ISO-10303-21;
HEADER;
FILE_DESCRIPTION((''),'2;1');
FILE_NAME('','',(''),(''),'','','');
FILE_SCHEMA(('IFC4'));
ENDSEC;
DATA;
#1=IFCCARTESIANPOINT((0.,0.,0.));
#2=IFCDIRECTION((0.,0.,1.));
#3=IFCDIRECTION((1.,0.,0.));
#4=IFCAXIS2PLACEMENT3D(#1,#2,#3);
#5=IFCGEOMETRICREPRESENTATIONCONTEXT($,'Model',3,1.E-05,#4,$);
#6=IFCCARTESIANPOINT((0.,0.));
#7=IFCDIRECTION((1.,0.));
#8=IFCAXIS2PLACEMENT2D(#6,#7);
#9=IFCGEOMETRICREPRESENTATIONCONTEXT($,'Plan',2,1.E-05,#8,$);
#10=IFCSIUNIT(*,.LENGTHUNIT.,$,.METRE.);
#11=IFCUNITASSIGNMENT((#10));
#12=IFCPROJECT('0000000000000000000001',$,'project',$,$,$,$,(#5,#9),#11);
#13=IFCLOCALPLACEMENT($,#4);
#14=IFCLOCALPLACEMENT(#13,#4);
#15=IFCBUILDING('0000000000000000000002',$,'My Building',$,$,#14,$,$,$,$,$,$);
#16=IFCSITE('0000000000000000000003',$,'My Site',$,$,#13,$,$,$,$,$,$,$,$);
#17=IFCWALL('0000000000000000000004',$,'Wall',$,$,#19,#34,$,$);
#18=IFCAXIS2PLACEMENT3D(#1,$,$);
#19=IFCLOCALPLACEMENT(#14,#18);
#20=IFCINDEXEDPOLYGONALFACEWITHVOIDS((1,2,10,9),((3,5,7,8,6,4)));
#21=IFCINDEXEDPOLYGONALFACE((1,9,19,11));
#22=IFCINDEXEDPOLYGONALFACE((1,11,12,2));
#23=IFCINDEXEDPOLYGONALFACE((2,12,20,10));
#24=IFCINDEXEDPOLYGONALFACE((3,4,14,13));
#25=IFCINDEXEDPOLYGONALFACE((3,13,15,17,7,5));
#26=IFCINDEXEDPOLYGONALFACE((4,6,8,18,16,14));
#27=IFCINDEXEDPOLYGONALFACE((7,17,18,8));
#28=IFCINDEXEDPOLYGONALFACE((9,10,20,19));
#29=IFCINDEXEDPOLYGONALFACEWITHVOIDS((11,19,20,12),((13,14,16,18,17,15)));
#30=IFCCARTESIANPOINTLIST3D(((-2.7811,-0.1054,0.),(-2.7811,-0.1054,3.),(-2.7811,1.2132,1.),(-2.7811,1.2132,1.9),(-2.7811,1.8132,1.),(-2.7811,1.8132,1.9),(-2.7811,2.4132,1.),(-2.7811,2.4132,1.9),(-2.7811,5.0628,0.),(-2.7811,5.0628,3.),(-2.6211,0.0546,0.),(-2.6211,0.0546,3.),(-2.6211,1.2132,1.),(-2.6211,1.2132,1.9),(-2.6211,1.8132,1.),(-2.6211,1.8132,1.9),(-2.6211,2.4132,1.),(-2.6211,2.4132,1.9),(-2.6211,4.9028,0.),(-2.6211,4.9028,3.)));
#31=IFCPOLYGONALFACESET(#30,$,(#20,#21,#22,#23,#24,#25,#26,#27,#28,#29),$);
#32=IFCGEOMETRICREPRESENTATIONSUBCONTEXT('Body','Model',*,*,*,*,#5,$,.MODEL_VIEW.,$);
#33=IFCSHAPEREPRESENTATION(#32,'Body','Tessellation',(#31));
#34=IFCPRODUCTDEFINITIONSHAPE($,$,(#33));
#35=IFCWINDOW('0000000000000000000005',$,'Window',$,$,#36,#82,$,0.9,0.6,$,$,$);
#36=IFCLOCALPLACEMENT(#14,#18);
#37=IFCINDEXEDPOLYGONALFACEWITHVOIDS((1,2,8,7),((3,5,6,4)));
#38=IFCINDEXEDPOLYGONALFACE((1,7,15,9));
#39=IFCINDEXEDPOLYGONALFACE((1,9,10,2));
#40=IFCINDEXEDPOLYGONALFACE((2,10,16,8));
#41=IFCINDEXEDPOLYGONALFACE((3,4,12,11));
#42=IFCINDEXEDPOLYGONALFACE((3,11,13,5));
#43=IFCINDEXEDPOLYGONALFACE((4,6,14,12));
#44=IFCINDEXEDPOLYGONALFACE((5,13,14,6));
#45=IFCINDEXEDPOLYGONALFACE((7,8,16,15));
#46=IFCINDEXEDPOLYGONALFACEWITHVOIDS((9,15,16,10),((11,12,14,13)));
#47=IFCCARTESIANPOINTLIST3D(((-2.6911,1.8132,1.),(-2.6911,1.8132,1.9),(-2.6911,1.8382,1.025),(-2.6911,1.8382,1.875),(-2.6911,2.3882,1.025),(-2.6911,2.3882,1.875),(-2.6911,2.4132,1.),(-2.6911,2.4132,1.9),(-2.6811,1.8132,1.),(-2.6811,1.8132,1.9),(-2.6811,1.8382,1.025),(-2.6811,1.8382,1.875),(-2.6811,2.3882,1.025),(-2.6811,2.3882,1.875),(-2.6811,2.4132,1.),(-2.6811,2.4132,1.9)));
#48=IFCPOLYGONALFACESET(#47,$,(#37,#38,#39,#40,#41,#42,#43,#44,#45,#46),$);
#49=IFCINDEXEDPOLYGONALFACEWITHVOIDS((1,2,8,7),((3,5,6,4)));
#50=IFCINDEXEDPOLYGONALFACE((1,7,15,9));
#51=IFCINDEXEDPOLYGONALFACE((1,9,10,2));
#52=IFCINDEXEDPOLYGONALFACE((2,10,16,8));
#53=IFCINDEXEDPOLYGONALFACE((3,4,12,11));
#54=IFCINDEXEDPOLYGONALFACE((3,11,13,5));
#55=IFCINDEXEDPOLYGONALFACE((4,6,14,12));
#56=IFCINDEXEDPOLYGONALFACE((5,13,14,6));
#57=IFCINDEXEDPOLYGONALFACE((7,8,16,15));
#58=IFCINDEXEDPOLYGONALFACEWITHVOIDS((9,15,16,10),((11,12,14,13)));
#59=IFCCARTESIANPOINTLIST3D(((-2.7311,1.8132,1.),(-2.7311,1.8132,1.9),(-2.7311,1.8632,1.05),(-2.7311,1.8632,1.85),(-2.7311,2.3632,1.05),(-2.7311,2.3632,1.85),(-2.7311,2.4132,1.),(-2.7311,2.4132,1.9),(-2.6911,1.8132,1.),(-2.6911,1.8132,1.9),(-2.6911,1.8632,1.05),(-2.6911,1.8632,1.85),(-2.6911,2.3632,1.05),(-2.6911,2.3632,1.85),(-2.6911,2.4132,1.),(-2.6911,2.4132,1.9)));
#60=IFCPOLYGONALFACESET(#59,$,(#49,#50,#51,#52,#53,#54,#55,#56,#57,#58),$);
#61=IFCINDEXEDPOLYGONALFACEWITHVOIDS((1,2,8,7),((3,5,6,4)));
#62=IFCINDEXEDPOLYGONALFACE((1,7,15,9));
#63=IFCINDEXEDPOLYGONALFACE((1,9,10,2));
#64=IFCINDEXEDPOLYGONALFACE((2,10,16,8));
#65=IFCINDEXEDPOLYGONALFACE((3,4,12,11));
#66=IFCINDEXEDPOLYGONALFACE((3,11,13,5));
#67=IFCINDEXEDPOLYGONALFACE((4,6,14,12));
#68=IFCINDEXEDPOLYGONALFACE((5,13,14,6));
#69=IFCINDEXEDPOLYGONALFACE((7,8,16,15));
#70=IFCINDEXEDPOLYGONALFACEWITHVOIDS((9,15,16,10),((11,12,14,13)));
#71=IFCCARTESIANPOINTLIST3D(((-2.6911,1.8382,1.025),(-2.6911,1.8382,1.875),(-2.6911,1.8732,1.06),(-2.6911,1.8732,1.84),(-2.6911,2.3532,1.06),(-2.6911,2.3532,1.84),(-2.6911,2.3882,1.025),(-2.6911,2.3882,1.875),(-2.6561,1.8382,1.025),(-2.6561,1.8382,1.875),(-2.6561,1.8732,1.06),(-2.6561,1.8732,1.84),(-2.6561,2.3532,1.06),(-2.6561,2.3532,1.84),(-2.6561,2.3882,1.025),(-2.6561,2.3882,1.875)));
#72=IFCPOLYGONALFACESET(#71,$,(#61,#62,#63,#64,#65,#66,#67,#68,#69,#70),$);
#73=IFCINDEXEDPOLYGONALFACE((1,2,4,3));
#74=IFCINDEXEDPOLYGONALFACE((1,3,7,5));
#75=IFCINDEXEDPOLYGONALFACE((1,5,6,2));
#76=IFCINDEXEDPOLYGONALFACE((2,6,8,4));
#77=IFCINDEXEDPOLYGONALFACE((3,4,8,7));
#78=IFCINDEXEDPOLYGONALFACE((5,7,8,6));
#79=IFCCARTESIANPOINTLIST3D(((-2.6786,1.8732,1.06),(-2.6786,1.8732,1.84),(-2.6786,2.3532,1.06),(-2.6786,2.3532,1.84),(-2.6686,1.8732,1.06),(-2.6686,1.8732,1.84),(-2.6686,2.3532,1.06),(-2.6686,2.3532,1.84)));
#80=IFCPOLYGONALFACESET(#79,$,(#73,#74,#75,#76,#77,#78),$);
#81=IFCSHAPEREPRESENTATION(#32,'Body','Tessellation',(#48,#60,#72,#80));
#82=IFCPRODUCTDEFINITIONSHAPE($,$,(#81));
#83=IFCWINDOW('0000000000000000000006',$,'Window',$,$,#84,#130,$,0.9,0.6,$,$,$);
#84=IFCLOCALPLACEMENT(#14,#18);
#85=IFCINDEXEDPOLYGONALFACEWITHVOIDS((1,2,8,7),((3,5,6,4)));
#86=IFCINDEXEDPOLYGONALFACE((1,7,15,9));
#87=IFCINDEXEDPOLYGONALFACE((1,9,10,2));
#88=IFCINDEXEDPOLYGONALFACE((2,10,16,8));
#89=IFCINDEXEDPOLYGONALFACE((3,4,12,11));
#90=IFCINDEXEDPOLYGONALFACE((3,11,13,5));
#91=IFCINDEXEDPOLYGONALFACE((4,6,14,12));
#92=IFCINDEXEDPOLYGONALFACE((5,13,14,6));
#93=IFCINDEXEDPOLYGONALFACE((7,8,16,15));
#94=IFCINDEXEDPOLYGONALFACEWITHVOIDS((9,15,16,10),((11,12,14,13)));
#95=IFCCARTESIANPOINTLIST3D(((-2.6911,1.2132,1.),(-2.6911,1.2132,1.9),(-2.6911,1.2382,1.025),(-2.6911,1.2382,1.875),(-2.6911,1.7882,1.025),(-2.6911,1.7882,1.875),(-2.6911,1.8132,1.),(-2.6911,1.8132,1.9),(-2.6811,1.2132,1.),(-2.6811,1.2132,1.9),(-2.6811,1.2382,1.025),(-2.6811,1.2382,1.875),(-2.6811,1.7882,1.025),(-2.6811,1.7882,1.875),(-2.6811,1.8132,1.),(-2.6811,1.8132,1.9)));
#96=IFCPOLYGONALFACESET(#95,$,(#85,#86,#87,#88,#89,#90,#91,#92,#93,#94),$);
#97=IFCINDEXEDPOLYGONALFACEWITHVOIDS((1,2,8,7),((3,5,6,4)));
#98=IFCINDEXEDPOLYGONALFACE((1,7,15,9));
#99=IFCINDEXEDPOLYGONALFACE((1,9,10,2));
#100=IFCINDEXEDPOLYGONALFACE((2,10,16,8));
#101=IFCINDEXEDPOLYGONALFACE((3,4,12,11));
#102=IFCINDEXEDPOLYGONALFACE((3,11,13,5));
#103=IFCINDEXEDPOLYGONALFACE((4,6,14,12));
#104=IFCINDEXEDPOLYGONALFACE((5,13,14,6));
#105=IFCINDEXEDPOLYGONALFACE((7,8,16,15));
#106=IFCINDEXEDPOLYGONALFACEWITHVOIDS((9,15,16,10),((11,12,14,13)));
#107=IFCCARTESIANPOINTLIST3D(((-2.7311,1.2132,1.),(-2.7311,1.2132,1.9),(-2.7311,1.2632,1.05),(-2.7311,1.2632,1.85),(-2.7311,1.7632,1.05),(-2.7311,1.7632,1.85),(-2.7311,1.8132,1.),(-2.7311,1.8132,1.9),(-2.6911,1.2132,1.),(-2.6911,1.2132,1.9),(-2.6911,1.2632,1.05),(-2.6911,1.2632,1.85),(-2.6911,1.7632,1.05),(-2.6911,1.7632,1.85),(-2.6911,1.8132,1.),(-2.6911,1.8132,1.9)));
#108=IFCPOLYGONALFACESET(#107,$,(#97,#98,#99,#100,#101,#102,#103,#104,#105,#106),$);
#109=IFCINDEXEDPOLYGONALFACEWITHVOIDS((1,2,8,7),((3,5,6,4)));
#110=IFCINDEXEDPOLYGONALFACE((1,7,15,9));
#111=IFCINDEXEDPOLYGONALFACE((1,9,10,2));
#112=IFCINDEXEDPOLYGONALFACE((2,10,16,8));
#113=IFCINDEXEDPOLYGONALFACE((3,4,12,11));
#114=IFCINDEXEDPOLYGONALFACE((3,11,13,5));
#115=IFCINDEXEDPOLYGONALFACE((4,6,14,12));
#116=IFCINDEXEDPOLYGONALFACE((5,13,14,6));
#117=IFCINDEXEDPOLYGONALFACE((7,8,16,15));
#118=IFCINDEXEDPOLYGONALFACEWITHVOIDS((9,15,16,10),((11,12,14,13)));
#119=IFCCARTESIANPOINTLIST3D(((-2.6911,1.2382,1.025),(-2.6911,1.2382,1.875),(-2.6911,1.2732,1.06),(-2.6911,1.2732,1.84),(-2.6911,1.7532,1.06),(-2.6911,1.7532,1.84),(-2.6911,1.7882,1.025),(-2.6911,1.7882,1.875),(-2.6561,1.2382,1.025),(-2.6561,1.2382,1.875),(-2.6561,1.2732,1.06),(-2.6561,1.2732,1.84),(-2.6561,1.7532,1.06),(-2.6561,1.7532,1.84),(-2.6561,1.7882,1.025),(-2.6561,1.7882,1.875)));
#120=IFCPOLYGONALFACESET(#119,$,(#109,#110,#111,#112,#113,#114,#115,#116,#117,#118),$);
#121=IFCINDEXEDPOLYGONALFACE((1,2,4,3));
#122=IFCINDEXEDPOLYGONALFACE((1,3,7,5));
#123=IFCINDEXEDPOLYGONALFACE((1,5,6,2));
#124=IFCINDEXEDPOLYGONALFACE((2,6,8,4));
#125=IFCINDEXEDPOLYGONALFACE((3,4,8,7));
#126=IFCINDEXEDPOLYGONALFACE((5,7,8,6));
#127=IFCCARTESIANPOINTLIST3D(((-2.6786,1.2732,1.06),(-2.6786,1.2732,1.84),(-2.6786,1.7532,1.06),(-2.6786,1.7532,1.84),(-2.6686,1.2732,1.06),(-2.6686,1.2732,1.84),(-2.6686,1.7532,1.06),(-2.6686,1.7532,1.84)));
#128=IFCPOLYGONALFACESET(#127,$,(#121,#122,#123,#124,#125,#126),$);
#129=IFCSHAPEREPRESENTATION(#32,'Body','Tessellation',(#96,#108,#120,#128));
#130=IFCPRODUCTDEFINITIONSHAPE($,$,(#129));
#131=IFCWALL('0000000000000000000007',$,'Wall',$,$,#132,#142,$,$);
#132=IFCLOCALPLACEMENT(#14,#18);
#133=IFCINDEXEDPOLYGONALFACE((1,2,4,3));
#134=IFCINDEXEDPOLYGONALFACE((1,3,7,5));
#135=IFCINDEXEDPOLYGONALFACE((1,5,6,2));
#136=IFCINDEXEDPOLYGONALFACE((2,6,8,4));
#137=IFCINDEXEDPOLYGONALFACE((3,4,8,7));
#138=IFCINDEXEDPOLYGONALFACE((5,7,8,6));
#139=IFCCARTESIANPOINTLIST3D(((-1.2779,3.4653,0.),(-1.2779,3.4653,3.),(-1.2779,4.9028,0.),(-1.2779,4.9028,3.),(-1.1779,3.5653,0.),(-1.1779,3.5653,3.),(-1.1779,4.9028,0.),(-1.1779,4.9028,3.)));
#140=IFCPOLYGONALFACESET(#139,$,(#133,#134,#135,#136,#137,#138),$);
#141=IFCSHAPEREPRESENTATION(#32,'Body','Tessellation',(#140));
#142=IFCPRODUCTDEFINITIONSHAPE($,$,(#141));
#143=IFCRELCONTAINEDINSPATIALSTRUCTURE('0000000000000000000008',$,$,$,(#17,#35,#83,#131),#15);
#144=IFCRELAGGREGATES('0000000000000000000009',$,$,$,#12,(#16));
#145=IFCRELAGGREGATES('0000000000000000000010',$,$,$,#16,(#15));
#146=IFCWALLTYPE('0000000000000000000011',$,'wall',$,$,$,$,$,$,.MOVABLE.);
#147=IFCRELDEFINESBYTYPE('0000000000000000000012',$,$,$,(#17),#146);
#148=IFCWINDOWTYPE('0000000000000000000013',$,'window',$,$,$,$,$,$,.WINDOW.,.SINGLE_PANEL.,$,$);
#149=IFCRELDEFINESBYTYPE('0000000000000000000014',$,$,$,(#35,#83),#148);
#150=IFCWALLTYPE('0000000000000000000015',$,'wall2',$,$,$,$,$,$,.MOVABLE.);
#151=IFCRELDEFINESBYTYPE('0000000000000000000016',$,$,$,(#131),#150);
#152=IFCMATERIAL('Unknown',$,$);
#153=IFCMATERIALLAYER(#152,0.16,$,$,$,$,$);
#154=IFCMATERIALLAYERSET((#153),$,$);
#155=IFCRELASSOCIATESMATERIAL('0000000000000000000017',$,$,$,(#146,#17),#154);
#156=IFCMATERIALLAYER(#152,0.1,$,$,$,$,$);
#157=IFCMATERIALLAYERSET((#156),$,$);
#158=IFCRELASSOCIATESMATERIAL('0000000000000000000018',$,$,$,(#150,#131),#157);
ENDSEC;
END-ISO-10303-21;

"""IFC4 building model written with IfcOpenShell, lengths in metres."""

from ifc_helpers import new_model, entity, si_unit, frame, origin_with_axes, origin_2d_with_axis, place, context, subcontext, project, spatial, line, indexed_curve, outline, extrude, shape, source, transform, mapped, material, layer, layer_set, layer_usage, type_object, type_shapes, element, fill, save


model = new_model("IFC4")

# Units and contexts
model_context = context("Model", 3, precision=1e-05, world=origin_with_axes())
plan_context = context("Plan", 2, precision=1e-05, world=origin_2d_with_axis())
body_context_1 = subcontext(model_context, "Body", "Model", "MODEL_VIEW")
body_context_2 = subcontext(plan_context, "Body", "Plan", "PLAN_VIEW")
ifc_project = project(units=[si_unit("LENGTHUNIT", "METRE")], contexts=[model_context, plan_context])

# Site, building
site_placement = place(None, origin_with_axes())
site = spatial("IfcSite", under=ifc_project, at=site_placement, Name="My Site")
building_placement = place(site_placement, origin_with_axes())
building = spatial("IfcBuilding", under=site, at=building_placement, Name="My Building")

# Shared definitions
ifc_material = material(Name="Unknown")

# Shared definitions
ifc_layer_1 = layer(ifc_material, 0.16)
ifc_layer_set_1 = layer_set([ifc_layer_1])
wall_type_1 = type_object("IfcWallType", Name="wall", PredefinedType="MOVABLE", material=ifc_layer_set_1)
shared_shape_1 = source(origin_with_axes(), body_context_1, "Body", "SweptSolid", [
    extrude(outline(indexed_curve([(0.0, 0.0), (0.6, 0.0), (0.6, 0.9), (0.0, 0.9)], segments=[line(1, 2, 3, 4, 1)])), frame((0.0, -0.6, 0.0), z_axis=(0.0, -1.0, 0.0), x_axis=(1.0, 0.0, 0.0)), (0.0, 0.0, -1.0), 1.2),
])
window_type = type_object("IfcWindowType", Name="window", PartitioningType="SINGLE_PANEL", PredefinedType="WINDOW")
shared_shape_2 = source(origin_with_axes(), body_context_1, "Body", "SweptSolid", [
    extrude(outline(indexed_curve([(0.0, 0.0), (0.6, 0.0), (0.6, 0.9), (0.0, 0.9)], segments=[line(1, 2, 3, 4, 1)]), holes=[indexed_curve([(0.025, 0.025), (0.575, 0.025), (0.575, 0.875), (0.025, 0.875)], segments=[line(1, 2, 3, 4, 1)])]), frame((0.0, 0.09, 0.0), z_axis=(0.0, -1.0, 0.0), x_axis=(1.0, 0.0, 0.0)), (0.0, 0.0, -1.0), 0.01),
    extrude(outline(indexed_curve([(0.0, 0.0), (0.6, 0.0), (0.6, 0.9), (0.0, 0.9)], segments=[line(1, 2, 3, 4, 1)]), holes=[indexed_curve([(0.05, 0.05), (0.55, 0.05), (0.55, 0.85), (0.05, 0.85)], segments=[line(1, 2, 3, 4, 1)])]), frame((0.0, 0.05, 0.0), z_axis=(0.0, -1.0, 0.0), x_axis=(1.0, 0.0, 0.0)), (0.0, 0.0, -1.0), 0.04),
    extrude(outline(indexed_curve([(0.0, 0.0), (0.55, 0.0), (0.55, 0.85), (0.0, 0.85)], segments=[line(1, 2, 3, 4, 1)]), holes=[indexed_curve([(0.035, 0.035), (0.515, 0.035), (0.515, 0.815), (0.035, 0.815)], segments=[line(1, 2, 3, 4, 1)])]), frame((0.025, 0.09, 0.025), z_axis=(0.0, -1.0, 0.0), x_axis=(1.0, 0.0, 0.0)), (0.0, 0.0, -1.0), 0.035),
    extrude(outline(indexed_curve([(0.035, 0.035), (0.515, 0.035), (0.515, 0.815), (0.035, 0.815)], segments=[line(1, 2, 3, 4, 1)])), frame((0.025, 0.1025, 0.025), z_axis=(0.0, -1.0, 0.0), x_axis=(1.0, 0.0, 0.0)), (0.0, 0.0, -1.0), 0.01),
])
shared_shape_3 = source(origin_with_axes(), body_context_2, "Body", "Curve2D", [
    entity("IfcIndexedPolyCurve", entity("IfcCartesianPointList2D", [[0.05, 0.05], [0.55, 0.05]])),
    entity("IfcIndexedPolyCurve", entity("IfcCartesianPointList2D", [[0.0, 0.1], [0.025, 0.1], [0.025, 0.09], [0.05, 0.09], [0.05, 0.05], [0.0, 0.05]]), [entity("IfcLineIndex", [1, 2, 3, 4, 5, 6, 1])]),
    entity("IfcIndexedPolyCurve", entity("IfcCartesianPointList2D", [[0.6, 0.1], [0.575, 0.1], [0.575, 0.09], [0.55, 0.09], [0.55, 0.05], [0.6, 0.05]]), [entity("IfcLineIndex", [1, 2, 3, 4, 5, 6, 1])]),
    entity("IfcIndexedPolyCurve", entity("IfcCartesianPointList2D", [[0.025, 0.09], [0.06, 0.09], [0.06, 0.125], [0.025, 0.125]]), [entity("IfcLineIndex", [1, 2, 3, 4, 1])]),
    entity("IfcIndexedPolyCurve", entity("IfcCartesianPointList2D", [[0.575, 0.09], [0.54, 0.09], [0.54, 0.125], [0.575, 0.125]]), [entity("IfcLineIndex", [1, 2, 3, 4, 1])]),
    entity("IfcIndexedPolyCurve", entity("IfcCartesianPointList2D", [[0.06, 0.09], [0.54, 0.09]])),
    entity("IfcIndexedPolyCurve", entity("IfcCartesianPointList2D", [[0.06, 0.125], [0.54, 0.125]])),
    entity("IfcIndexedPolyCurve", entity("IfcCartesianPointList2D", [[0.06, 0.1075], [0.54, 0.1075]])),
])
type_shapes(window_type, [shared_shape_2, shared_shape_3])

# Wall, openings, windows
ifc_layer_usage_1 = layer_usage(ifc_layer_set_1, "AXIS2", "POSITIVE", 0.0)
wall_1_placement = place(building_placement, frame((-2.6211, 0.0546, 0.0), z_axis=(0.0, 0.0, 1.0), x_axis=(0.0, 1.0, 0.0)))
wall_1 = element("IfcWall", 1, at=wall_1_placement, inside=building, type_object=wall_type_1, material=ifc_layer_usage_1, Name="Wall", context=body_context_1, shape_type="SweptSolid", body=[
    extrude(outline(indexed_curve([(0.0, 0.0), (-0.16, 0.16), (5.0082, 0.16), (4.8482, 0.0)], segments=[line(1, 2, 3, 4, 1)])), origin_with_axes(), (0.0, 0.0, 1.0), 3.0),
])
opening_1_placement = place(wall_1_placement, frame((2.3586, 0.16, 1.0), z_axis=(0.0, 0.0, 1.0), x_axis=(-1.0, 0.0, 0.0)))
opening_1 = element("IfcOpeningElement", 2, at=opening_1_placement, cuts=wall_1, PredefinedType="OPENING", context=body_context_1, shape_type="MappedRepresentation", body=[
    mapped(shared_shape_1, transform((0.0, 0.0, 0.0), x_axis=(1.0, 0.0, 0.0), y_axis=(0.0, 1.0, 0.0), z_axis=(0.0, 0.0, 1.0), scale=1.0)),
])
opening_2_placement = place(wall_1_placement, frame((1.7586, 0.16, 1.0), z_axis=(0.0, 0.0, 1.0), x_axis=(-1.0, 0.0, 0.0)))
opening_2 = element("IfcOpeningElement", 3, at=opening_2_placement, cuts=wall_1, PredefinedType="OPENING", context=body_context_1, shape_type="MappedRepresentation", body=[
    mapped(shared_shape_1, transform((0.0, 0.0, 0.0), x_axis=(1.0, 0.0, 0.0), y_axis=(0.0, 1.0, 0.0), z_axis=(0.0, 0.0, 1.0), scale=1.0)),
])
window_1_placement = place(opening_1_placement, frame((0.0, 0.0, 0.0), z_axis=(0.0, 0.0, 1.0), x_axis=(1.0, 0.0, 0.0)))
window_1 = element("IfcWindow", 4, at=window_1_placement, inside=building, type_object=window_type, Name="Window", OverallHeight=0.9, OverallWidth=0.6, shapes=[
    shape(body_context_1, "Body", "MappedRepresentation", [mapped(shared_shape_2, transform((0.0, 0.0, 0.0), x_axis=(1.0, 0.0, 0.0), y_axis=(0.0, 1.0, 0.0), z_axis=(0.0, 0.0, 1.0), scale=1.0))]),
    shape(body_context_2, "Body", "MappedRepresentation", [mapped(shared_shape_3, transform((0.0, 0.0, 0.0), x_axis=(1.0, 0.0, 0.0), y_axis=(0.0, 1.0, 0.0), z_axis=(0.0, 0.0, 1.0), scale=1.0))]),
])
fill(opening_1, window_1)
window_2_placement = place(opening_2_placement, frame((0.0, 0.0, 0.0), z_axis=(0.0, 0.0, 1.0), x_axis=(1.0, 0.0, 0.0)))
window_2 = element("IfcWindow", 5, at=window_2_placement, inside=building, type_object=window_type, Name="Window", OverallHeight=0.9, OverallWidth=0.6, shapes=[
    shape(body_context_1, "Body", "MappedRepresentation", [mapped(shared_shape_2, transform((0.0, 0.0, 0.0), x_axis=(1.0, 0.0, 0.0), y_axis=(0.0, 1.0, 0.0), z_axis=(0.0, 0.0, 1.0), scale=1.0))]),
    shape(body_context_2, "Body", "MappedRepresentation", [mapped(shared_shape_3, transform((0.0, 0.0, 0.0), x_axis=(1.0, 0.0, 0.0), y_axis=(0.0, 1.0, 0.0), z_axis=(0.0, 0.0, 1.0), scale=1.0))]),
])
fill(opening_2, window_2)

# Wall
ifc_layer_2 = layer(ifc_material, 0.1)
ifc_layer_set_2 = layer_set([ifc_layer_2])
ifc_layer_usage_2 = layer_usage(ifc_layer_set_2, "AXIS2", "POSITIVE", 0.0)
wall_type_2 = type_object("IfcWallType", Name="wall2", PredefinedType="MOVABLE", material=ifc_layer_set_2)
wall_2_placement = place(building_placement, frame((-1.2779, 4.9028, 0.0), z_axis=(0.0, 0.0, 1.0), x_axis=(0.0, -1.0, 0.0)))
element("IfcWall", 6, at=wall_2_placement, inside=building, type_object=wall_type_2, material=ifc_layer_usage_2, Name="Wall", context=body_context_1, shape_type="SweptSolid", body=[
    extrude(outline(indexed_curve([(0.0, 0.0), (0.0, 0.1), (1.3375, 0.1), (1.4375, 0.0)], segments=[line(1, 2, 3, 4, 1)])), origin_with_axes(), (0.0, 0.0, 1.0), 3.0),
])

save(model, "model.ifc")
